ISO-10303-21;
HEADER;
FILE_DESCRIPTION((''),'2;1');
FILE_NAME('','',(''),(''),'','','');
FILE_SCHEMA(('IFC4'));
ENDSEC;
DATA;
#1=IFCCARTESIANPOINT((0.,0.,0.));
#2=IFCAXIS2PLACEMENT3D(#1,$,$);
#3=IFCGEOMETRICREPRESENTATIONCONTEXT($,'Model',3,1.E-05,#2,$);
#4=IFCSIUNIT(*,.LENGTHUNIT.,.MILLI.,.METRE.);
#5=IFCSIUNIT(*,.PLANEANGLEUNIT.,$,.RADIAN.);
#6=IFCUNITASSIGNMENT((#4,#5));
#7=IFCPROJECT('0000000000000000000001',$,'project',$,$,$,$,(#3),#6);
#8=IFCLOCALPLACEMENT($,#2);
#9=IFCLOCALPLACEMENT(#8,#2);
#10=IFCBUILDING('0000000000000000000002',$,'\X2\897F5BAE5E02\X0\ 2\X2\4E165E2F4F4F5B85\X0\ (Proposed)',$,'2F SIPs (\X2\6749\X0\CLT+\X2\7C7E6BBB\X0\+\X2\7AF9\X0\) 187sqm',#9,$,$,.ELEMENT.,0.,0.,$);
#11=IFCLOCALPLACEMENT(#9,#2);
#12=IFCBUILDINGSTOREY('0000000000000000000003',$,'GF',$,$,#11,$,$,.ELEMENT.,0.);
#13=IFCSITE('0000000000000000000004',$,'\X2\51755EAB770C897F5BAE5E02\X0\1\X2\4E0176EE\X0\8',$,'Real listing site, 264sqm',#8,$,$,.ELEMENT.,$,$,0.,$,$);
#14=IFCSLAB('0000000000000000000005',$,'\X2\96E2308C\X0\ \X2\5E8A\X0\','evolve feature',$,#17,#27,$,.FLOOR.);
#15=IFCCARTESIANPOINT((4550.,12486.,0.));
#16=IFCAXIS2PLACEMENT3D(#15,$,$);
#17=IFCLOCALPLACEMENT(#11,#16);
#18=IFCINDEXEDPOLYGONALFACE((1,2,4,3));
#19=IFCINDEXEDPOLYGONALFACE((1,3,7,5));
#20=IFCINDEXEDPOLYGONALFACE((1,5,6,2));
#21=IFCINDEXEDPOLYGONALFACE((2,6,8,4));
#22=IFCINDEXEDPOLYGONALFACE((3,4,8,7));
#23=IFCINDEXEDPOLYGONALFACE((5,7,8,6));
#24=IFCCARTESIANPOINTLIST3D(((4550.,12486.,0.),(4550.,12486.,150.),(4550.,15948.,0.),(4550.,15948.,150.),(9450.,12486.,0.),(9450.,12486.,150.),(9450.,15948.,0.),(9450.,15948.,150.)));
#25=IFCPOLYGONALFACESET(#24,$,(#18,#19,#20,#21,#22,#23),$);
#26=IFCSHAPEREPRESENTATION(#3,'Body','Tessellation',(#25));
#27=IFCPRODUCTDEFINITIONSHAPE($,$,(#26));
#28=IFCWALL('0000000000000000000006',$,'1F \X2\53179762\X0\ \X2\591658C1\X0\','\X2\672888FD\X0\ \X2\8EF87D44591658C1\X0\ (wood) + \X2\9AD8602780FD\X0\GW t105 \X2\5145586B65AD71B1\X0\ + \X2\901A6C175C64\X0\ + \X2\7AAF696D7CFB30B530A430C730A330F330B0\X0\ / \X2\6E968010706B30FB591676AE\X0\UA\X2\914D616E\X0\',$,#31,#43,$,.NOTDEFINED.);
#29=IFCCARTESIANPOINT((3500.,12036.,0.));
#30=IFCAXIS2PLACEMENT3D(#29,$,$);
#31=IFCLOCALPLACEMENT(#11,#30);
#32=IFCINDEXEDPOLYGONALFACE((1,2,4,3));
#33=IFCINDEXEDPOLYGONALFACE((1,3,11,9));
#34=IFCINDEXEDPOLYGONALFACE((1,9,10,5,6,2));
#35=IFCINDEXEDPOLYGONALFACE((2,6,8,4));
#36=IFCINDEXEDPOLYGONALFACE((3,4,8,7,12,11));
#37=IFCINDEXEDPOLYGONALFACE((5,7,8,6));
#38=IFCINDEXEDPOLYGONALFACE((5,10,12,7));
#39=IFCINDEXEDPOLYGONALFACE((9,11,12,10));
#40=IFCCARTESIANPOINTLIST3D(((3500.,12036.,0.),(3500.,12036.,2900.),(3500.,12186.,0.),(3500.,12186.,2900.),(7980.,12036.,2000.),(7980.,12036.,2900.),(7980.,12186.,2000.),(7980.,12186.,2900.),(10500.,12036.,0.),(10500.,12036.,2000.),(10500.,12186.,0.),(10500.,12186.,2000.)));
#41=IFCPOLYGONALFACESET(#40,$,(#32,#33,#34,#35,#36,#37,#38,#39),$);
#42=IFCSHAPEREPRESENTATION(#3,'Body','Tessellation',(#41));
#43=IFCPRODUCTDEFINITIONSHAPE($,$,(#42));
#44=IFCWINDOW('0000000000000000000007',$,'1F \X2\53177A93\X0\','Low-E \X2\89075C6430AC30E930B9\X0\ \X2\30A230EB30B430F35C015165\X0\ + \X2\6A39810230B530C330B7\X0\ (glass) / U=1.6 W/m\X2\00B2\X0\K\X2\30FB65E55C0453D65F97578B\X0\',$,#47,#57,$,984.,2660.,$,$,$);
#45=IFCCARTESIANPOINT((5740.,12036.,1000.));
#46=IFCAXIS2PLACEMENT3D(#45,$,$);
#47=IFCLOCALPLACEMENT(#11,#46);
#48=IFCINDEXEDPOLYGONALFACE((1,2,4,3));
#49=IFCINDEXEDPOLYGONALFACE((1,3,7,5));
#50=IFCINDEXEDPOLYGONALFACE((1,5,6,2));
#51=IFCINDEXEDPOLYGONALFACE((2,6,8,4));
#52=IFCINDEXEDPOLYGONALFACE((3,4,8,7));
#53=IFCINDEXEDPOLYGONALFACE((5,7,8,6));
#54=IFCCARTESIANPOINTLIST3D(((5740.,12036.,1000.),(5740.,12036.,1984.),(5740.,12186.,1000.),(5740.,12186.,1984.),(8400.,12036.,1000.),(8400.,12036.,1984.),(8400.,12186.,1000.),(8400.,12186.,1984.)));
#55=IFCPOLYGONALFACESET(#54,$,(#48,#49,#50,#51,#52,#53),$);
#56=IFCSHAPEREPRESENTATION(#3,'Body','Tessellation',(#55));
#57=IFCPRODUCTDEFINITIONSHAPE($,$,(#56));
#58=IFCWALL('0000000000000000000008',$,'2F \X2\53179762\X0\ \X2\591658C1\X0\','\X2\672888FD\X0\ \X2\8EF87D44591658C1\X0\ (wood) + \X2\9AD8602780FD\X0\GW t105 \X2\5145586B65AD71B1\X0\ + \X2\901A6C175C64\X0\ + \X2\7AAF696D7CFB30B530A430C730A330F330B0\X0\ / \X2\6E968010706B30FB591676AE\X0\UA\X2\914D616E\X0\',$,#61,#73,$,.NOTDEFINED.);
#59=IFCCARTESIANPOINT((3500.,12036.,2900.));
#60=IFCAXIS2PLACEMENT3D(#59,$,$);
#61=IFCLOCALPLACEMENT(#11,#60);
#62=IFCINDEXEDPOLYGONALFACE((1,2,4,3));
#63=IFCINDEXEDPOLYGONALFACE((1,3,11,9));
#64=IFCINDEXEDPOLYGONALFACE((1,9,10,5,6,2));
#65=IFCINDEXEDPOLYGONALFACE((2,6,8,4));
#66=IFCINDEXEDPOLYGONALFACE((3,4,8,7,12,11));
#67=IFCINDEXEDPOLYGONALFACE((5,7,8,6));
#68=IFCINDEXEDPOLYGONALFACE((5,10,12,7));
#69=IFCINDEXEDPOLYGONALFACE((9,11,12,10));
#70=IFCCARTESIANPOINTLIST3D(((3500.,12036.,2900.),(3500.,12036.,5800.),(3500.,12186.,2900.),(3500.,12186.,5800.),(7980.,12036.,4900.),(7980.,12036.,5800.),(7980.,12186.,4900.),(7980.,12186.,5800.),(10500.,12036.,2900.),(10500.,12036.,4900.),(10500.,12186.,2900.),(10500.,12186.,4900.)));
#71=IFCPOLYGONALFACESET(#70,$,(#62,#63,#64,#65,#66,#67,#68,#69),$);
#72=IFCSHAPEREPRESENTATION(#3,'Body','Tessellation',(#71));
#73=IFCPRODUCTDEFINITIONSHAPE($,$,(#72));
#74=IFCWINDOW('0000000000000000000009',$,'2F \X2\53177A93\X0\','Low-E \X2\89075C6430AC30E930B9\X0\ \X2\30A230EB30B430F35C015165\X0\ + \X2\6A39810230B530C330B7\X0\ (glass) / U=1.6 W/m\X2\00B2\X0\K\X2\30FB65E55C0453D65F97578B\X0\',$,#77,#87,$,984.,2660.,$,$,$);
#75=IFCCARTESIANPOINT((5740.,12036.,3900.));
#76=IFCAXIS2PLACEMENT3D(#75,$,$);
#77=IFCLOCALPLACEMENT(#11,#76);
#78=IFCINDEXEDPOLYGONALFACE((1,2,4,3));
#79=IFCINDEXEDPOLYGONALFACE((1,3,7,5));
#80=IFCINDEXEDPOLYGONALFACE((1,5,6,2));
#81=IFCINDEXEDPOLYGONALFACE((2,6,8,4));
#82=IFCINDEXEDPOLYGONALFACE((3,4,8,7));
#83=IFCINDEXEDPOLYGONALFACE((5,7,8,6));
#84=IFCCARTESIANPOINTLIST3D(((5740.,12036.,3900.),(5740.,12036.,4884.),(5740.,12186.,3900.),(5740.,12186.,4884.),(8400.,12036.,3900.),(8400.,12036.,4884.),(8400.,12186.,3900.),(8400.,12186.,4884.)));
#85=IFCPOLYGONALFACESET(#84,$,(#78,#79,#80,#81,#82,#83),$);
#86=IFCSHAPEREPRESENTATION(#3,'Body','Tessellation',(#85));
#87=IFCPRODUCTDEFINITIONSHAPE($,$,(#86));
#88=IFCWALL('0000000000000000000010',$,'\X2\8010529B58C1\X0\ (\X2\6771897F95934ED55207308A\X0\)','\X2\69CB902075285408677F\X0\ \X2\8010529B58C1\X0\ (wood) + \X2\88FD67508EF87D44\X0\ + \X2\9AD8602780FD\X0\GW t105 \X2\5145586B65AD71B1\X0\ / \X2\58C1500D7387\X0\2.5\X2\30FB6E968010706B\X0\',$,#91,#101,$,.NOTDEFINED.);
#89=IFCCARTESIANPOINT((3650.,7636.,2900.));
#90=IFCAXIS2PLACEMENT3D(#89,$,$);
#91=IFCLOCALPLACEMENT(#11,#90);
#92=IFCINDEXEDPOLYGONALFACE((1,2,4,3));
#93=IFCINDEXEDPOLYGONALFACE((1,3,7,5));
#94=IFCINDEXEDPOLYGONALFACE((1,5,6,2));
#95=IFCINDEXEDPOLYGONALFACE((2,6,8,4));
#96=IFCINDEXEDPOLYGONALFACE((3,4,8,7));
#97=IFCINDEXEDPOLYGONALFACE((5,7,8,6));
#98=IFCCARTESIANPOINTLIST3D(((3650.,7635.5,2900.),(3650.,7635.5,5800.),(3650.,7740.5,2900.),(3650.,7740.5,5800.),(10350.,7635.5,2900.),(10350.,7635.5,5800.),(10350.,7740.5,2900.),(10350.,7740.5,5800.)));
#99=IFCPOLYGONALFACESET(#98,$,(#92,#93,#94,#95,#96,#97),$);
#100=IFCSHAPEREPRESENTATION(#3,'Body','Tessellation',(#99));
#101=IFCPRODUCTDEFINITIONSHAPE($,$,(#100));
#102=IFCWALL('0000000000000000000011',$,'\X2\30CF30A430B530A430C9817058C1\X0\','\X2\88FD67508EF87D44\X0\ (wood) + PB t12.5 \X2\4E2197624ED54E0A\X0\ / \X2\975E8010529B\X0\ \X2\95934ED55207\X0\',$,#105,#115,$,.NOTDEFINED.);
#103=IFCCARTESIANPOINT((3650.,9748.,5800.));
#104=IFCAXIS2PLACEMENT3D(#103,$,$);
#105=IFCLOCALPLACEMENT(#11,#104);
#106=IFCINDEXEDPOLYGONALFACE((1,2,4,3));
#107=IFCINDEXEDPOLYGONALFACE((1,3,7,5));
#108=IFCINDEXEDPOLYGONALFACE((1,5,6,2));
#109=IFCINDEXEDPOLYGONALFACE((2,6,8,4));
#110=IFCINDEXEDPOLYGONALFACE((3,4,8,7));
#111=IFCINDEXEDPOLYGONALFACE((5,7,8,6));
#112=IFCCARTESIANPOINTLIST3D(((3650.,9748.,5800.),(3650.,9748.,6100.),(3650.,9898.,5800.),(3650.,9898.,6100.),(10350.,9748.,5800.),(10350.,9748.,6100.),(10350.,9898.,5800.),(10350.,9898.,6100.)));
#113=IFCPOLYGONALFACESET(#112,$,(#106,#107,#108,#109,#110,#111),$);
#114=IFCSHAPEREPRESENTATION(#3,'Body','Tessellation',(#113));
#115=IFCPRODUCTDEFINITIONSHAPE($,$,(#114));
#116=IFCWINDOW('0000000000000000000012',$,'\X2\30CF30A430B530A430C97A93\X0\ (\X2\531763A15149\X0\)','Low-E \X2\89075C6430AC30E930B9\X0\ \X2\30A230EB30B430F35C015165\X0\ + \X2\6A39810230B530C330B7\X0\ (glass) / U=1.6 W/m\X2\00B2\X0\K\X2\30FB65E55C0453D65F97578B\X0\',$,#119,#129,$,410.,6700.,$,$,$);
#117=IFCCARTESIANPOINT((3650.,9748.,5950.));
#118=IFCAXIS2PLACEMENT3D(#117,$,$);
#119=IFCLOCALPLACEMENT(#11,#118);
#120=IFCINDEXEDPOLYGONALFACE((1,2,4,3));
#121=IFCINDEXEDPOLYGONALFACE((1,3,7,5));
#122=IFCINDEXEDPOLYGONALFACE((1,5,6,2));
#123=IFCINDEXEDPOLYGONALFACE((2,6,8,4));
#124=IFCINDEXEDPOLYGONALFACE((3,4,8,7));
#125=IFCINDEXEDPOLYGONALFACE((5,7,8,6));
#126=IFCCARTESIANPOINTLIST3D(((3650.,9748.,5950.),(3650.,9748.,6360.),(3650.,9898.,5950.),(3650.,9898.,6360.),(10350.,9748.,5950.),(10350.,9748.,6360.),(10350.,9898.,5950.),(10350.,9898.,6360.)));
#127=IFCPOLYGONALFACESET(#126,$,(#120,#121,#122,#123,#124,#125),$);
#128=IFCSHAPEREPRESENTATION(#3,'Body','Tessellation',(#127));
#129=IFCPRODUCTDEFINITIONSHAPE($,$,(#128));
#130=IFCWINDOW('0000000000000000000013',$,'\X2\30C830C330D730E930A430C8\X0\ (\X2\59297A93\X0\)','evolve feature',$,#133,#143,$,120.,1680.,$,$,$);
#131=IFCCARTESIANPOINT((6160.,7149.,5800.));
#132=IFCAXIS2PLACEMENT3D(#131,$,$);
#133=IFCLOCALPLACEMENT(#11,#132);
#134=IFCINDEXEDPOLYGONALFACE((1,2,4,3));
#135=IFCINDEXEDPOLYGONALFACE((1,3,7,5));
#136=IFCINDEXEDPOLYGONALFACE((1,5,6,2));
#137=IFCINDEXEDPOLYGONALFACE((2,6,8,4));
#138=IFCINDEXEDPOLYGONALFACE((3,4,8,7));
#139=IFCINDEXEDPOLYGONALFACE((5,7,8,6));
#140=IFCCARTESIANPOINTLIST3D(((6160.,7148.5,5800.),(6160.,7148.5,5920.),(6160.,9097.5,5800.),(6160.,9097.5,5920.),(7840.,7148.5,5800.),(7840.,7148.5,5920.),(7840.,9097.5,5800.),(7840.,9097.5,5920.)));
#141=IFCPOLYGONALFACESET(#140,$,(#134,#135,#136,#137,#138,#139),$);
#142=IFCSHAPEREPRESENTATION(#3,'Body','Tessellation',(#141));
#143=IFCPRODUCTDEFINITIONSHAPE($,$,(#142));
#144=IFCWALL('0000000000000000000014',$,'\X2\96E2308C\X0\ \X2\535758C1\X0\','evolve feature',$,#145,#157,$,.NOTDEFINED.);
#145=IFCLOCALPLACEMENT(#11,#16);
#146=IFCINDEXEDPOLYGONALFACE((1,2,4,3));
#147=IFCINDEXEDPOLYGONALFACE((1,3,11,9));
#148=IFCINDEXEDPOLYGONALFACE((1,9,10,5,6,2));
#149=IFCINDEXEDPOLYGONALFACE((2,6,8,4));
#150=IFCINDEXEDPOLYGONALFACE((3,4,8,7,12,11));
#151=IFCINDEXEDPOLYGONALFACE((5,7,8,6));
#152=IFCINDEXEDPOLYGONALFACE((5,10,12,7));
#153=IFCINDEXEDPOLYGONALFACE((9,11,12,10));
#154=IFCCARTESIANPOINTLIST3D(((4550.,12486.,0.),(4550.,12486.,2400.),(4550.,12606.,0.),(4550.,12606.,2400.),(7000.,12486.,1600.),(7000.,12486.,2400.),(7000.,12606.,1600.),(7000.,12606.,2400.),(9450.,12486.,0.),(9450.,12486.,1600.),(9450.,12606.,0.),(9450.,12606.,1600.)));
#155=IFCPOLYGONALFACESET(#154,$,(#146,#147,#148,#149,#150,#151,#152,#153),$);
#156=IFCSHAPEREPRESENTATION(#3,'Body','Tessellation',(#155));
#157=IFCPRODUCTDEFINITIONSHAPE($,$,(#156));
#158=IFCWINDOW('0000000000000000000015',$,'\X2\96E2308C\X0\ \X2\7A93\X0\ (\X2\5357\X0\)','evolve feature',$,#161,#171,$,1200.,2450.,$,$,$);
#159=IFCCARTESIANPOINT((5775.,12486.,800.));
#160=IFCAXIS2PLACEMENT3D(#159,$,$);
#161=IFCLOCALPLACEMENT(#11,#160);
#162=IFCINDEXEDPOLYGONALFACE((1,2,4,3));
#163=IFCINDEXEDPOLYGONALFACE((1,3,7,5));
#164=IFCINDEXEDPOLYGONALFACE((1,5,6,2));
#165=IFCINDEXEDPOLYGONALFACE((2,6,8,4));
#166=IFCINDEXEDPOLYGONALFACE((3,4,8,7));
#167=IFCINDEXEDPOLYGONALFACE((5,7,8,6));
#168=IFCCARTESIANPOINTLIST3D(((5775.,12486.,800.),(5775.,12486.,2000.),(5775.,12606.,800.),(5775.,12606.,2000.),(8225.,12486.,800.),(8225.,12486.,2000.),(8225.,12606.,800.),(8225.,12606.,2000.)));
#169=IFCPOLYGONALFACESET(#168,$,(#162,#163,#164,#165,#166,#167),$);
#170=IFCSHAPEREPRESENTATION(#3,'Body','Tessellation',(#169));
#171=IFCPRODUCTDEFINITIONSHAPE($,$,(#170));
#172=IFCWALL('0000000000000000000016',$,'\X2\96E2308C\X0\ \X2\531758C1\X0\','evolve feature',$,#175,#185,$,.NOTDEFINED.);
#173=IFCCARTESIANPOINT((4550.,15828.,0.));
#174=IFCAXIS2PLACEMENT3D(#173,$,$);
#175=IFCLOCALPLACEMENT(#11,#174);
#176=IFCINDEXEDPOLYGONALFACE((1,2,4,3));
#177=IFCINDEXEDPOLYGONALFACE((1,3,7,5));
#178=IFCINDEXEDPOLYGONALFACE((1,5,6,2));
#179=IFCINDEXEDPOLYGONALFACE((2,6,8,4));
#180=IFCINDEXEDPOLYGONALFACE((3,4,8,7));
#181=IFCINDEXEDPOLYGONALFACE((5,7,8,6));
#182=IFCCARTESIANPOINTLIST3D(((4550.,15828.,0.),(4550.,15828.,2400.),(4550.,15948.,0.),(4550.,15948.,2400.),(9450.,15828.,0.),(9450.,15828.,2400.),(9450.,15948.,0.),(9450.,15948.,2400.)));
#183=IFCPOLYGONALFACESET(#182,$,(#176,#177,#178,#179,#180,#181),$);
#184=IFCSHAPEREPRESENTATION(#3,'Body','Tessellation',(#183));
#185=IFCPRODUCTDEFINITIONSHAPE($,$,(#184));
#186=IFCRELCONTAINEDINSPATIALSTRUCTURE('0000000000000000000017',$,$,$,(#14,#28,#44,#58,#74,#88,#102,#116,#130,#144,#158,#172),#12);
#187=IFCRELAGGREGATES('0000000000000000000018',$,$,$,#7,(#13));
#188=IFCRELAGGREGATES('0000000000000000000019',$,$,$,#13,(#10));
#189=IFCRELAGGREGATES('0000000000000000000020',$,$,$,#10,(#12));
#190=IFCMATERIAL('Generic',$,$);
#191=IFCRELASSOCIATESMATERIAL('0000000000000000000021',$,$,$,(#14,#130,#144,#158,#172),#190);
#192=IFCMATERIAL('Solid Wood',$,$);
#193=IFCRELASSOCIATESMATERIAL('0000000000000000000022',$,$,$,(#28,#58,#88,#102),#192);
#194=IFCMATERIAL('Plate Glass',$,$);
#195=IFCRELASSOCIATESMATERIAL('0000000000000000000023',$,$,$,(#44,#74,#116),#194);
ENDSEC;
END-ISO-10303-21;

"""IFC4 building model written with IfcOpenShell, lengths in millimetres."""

from ifc_helpers import new_model, si_unit, frame, frame_2d, origin, place, context, project, spatial, rectangle, extrude, material, element, fill, save


model = new_model("IFC4")

# Units and contexts
model_context = context("Model", 3, precision=1e-05, world=origin())
ifc_project = project(units=[si_unit("LENGTHUNIT", "METRE", prefix="MILLI"), si_unit("PLANEANGLEUNIT", "RADIAN")], contexts=[model_context])

# Site, building, storey
site_placement = place(None, origin())
site = spatial("IfcSite", under=ifc_project, at=site_placement, Name="兵庫県西宮市1丁目8", ObjectType="Real listing site, 264sqm", CompositionType="ELEMENT", RefElevation=0.0)
building_placement = place(site_placement, origin())
building = spatial("IfcBuilding", under=site, at=building_placement, Name="西宮市 2世帯住宅 (Proposed)", ObjectType="2F SIPs (杉CLT+籾殻+竹) 187sqm", CompositionType="ELEMENT", ElevationOfRefHeight=0.0, ElevationOfTerrain=0.0)
storey_placement = place(building_placement, origin())
storey = spatial("IfcBuildingStorey", under=building, at=storey_placement, Name="GF", CompositionType="ELEMENT", Elevation=0.0)

# Slab
ifc_material_1 = material(Name="Generic")
slab_placement = place(storey_placement, frame((4550.0, 12486.0, 0.0)))
element("IfcSlab", 1, at=slab_placement, inside=storey, material=ifc_material_1, Name="離れ 床", Description="evolve feature", PredefinedType="FLOOR", context=model_context, shape_type="SweptSolid", body=[
    extrude(rectangle(XDim=4900.0, YDim=3462.0, at=frame_2d((2450.0, 1731.0))), frame((4550.0, 12486.0, 0.0)), (0.0, 0.0, 1.0), 150.0),
])

# Wall, opening, window
ifc_material_2 = material(Name="Solid Wood")
wall_1_placement = place(storey_placement, frame((3500.0, 12036.0, 0.0)))
wall_1 = element("IfcWall", 2, at=wall_1_placement, inside=storey, material=ifc_material_2, Name="1F 北面 外壁", Description="木製 軸組外壁 (wood) + 高性能GW t105 充填断熱 + 通気層 + 窯業系サイディング / 準耐火・外皮UA配慮", PredefinedType="NOTDEFINED", context=model_context, shape_type="SweptSolid", body=[
    extrude(rectangle(XDim=7000.0, YDim=150.0, at=frame_2d((3500.0, 75.0))), frame((3500.0, 12036.0, 0.0)), (0.0, 0.0, 1.0), 2900.0),
])
opening_1_placement = place(storey_placement, frame((5740.0, 12036.0, 1000.0)))
opening_1 = element("IfcOpeningElement", 3, at=opening_1_placement, cuts=wall_1, PredefinedType="NOTDEFINED", context=model_context, shape_type="SweptSolid", body=[
    extrude(rectangle(XDim=2660.0, YDim=150.0, at=frame_2d((1330.0, 75.0))), frame((5740.0, 12036.0, 1000.0)), (0.0, 0.0, 1.0), 984.0),
])
ifc_material_3 = material(Name="Plate Glass")
window_1_placement = place(storey_placement, frame((5740.0, 12036.0, 1000.0)))
window_1 = element("IfcWindow", 4, at=window_1_placement, inside=storey, material=ifc_material_3, Name="1F 北窓", Description="Low-E 複層ガラス アルゴン封入 + 樹脂サッシ (glass) / U=1.6 W/m²K・日射取得型", OverallHeight=984.0, OverallWidth=2660.0, context=model_context, shape_type="SweptSolid", body=[
    extrude(rectangle(XDim=2660.0, YDim=150.0, at=frame_2d((1330.0, 75.0))), frame((5740.0, 12036.0, 1000.0)), (0.0, 0.0, 1.0), 984.0),
])
fill(opening_1, window_1)

# Wall, opening, window
wall_2_placement = place(storey_placement, frame((3500.0, 12036.0, 2900.0)))
wall_2 = element("IfcWall", 5, at=wall_2_placement, inside=storey, material=ifc_material_2, Name="2F 北面 外壁", Description="木製 軸組外壁 (wood) + 高性能GW t105 充填断熱 + 通気層 + 窯業系サイディング / 準耐火・外皮UA配慮", PredefinedType="NOTDEFINED", context=model_context, shape_type="SweptSolid", body=[
    extrude(rectangle(XDim=7000.0, YDim=150.0, at=frame_2d((3500.0, 75.0))), frame((3500.0, 12036.0, 2900.0)), (0.0, 0.0, 1.0), 2900.0),
])
opening_2_placement = place(storey_placement, frame((5740.0, 12036.0, 3900.0)))
opening_2 = element("IfcOpeningElement", 6, at=opening_2_placement, cuts=wall_2, PredefinedType="NOTDEFINED", context=model_context, shape_type="SweptSolid", body=[
    extrude(rectangle(XDim=2660.0, YDim=150.0, at=frame_2d((1330.0, 75.0))), frame((5740.0, 12036.0, 3900.0)), (0.0, 0.0, 1.0), 984.0),
])
window_2_placement = place(storey_placement, frame((5740.0, 12036.0, 3900.0)))
window_2 = element("IfcWindow", 7, at=window_2_placement, inside=storey, material=ifc_material_3, Name="2F 北窓", Description="Low-E 複層ガラス アルゴン封入 + 樹脂サッシ (glass) / U=1.6 W/m²K・日射取得型", OverallHeight=984.0, OverallWidth=2660.0, context=model_context, shape_type="SweptSolid", body=[
    extrude(rectangle(XDim=2660.0, YDim=150.0, at=frame_2d((1330.0, 75.0))), frame((5740.0, 12036.0, 3900.0)), (0.0, 0.0, 1.0), 984.0),
])
fill(opening_2, window_2)

# Wall
wall_3_placement = place(storey_placement, frame((3650.0, 7636.0, 2900.0)))
element("IfcWall", 8, at=wall_3_placement, inside=storey, material=ifc_material_2, Name="耐力壁 (東西間仕切り)", Description="構造用合板 耐力壁 (wood) + 製材軸組 + 高性能GW t105 充填断熱 / 壁倍率2.5・準耐火", PredefinedType="NOTDEFINED", context=model_context, shape_type="SweptSolid", body=[
    extrude(rectangle(XDim=6700.0, YDim=105.0, at=frame_2d((3350.0, 52.0))), frame((3650.0, 7636.0, 2900.0)), (0.0, 0.0, 1.0), 2900.0),
])

# Wall, opening, window
wall_4_placement = place(storey_placement, frame((3650.0, 9748.0, 5800.0)))
wall_4 = element("IfcWall", 9, at=wall_4_placement, inside=storey, material=ifc_material_2, Name="ハイサイド腰壁", Description="製材軸組 (wood) + PB t12.5 両面仕上 / 非耐力 間仕切", PredefinedType="NOTDEFINED", context=model_context, shape_type="SweptSolid", body=[
    extrude(rectangle(XDim=6700.0, YDim=150.0, at=frame_2d((3350.0, 75.0))), frame((3650.0, 9748.0, 5800.0)), (0.0, 0.0, 1.0), 700.0),
])
opening_3_placement = place(storey_placement, frame((3650.0, 9748.0, 5950.0)))
opening_3 = element("IfcOpeningElement", 10, at=opening_3_placement, cuts=wall_4, PredefinedType="NOTDEFINED", context=model_context, shape_type="SweptSolid", body=[
    extrude(rectangle(XDim=6700.0, YDim=150.0, at=frame_2d((3350.0, 75.0))), frame((3650.0, 9748.0, 5950.0)), (0.0, 0.0, 1.0), 410.0),
])
window_3_placement = place(storey_placement, frame((3650.0, 9748.0, 5950.0)))
window_3 = element("IfcWindow", 11, at=window_3_placement, inside=storey, material=ifc_material_3, Name="ハイサイド窓 (北採光)", Description="Low-E 複層ガラス アルゴン封入 + 樹脂サッシ (glass) / U=1.6 W/m²K・日射取得型", OverallHeight=410.0, OverallWidth=6700.0, context=model_context, shape_type="SweptSolid", body=[
    extrude(rectangle(XDim=6700.0, YDim=150.0, at=frame_2d((3350.0, 75.0))), frame((3650.0, 9748.0, 5950.0)), (0.0, 0.0, 1.0), 410.0),
])
fill(opening_3, window_3)

# Window
window_4_placement = place(storey_placement, frame((6160.0, 7149.0, 5800.0)))
element("IfcWindow", 12, at=window_4_placement, inside=storey, material=ifc_material_1, Name="トップライト (天窓)", Description="evolve feature", OverallHeight=120.0, OverallWidth=1680.0, context=model_context, shape_type="SweptSolid", body=[
    extrude(rectangle(XDim=1680.0, YDim=1949.0, at=frame_2d((840.0, 974.0))), frame((6160.0, 7149.0, 5800.0)), (0.0, 0.0, 1.0), 120.0),
])

# Wall, opening, window
wall_5_placement = place(storey_placement, frame((4550.0, 12486.0, 0.0)))
wall_5 = element("IfcWall", 13, at=wall_5_placement, inside=storey, material=ifc_material_1, Name="離れ 南壁", Description="evolve feature", PredefinedType="NOTDEFINED", context=model_context, shape_type="SweptSolid", body=[
    extrude(rectangle(XDim=4900.0, YDim=120.0, at=frame_2d((2450.0, 60.0))), frame((4550.0, 12486.0, 0.0)), (0.0, 0.0, 1.0), 2400.0),
])
opening_4_placement = place(storey_placement, frame((5775.0, 12486.0, 800.0)))
opening_4 = element("IfcOpeningElement", 14, at=opening_4_placement, cuts=wall_5, PredefinedType="NOTDEFINED", context=model_context, shape_type="SweptSolid", body=[
    extrude(rectangle(XDim=2450.0, YDim=120.0, at=frame_2d((1225.0, 60.0))), frame((5775.0, 12486.0, 800.0)), (0.0, 0.0, 1.0), 1200.0),
])
window_5_placement = place(storey_placement, frame((5775.0, 12486.0, 800.0)))
window_5 = element("IfcWindow", 15, at=window_5_placement, inside=storey, material=ifc_material_1, Name="離れ 窓 (南)", Description="evolve feature", OverallHeight=1200.0, OverallWidth=2450.0, context=model_context, shape_type="SweptSolid", body=[
    extrude(rectangle(XDim=2450.0, YDim=120.0, at=frame_2d((1225.0, 60.0))), frame((5775.0, 12486.0, 800.0)), (0.0, 0.0, 1.0), 1200.0),
])
fill(opening_4, window_5)

# Wall
wall_6_placement = place(storey_placement, frame((4550.0, 15828.0, 0.0)))
element("IfcWall", 16, at=wall_6_placement, inside=storey, material=ifc_material_1, Name="離れ 北壁", Description="evolve feature", PredefinedType="NOTDEFINED", context=model_context, shape_type="SweptSolid", body=[
    extrude(rectangle(XDim=4900.0, YDim=120.0, at=frame_2d((2450.0, 60.0))), frame((4550.0, 15828.0, 0.0)), (0.0, 0.0, 1.0), 2400.0),
])

save(model, "model.ifc")
